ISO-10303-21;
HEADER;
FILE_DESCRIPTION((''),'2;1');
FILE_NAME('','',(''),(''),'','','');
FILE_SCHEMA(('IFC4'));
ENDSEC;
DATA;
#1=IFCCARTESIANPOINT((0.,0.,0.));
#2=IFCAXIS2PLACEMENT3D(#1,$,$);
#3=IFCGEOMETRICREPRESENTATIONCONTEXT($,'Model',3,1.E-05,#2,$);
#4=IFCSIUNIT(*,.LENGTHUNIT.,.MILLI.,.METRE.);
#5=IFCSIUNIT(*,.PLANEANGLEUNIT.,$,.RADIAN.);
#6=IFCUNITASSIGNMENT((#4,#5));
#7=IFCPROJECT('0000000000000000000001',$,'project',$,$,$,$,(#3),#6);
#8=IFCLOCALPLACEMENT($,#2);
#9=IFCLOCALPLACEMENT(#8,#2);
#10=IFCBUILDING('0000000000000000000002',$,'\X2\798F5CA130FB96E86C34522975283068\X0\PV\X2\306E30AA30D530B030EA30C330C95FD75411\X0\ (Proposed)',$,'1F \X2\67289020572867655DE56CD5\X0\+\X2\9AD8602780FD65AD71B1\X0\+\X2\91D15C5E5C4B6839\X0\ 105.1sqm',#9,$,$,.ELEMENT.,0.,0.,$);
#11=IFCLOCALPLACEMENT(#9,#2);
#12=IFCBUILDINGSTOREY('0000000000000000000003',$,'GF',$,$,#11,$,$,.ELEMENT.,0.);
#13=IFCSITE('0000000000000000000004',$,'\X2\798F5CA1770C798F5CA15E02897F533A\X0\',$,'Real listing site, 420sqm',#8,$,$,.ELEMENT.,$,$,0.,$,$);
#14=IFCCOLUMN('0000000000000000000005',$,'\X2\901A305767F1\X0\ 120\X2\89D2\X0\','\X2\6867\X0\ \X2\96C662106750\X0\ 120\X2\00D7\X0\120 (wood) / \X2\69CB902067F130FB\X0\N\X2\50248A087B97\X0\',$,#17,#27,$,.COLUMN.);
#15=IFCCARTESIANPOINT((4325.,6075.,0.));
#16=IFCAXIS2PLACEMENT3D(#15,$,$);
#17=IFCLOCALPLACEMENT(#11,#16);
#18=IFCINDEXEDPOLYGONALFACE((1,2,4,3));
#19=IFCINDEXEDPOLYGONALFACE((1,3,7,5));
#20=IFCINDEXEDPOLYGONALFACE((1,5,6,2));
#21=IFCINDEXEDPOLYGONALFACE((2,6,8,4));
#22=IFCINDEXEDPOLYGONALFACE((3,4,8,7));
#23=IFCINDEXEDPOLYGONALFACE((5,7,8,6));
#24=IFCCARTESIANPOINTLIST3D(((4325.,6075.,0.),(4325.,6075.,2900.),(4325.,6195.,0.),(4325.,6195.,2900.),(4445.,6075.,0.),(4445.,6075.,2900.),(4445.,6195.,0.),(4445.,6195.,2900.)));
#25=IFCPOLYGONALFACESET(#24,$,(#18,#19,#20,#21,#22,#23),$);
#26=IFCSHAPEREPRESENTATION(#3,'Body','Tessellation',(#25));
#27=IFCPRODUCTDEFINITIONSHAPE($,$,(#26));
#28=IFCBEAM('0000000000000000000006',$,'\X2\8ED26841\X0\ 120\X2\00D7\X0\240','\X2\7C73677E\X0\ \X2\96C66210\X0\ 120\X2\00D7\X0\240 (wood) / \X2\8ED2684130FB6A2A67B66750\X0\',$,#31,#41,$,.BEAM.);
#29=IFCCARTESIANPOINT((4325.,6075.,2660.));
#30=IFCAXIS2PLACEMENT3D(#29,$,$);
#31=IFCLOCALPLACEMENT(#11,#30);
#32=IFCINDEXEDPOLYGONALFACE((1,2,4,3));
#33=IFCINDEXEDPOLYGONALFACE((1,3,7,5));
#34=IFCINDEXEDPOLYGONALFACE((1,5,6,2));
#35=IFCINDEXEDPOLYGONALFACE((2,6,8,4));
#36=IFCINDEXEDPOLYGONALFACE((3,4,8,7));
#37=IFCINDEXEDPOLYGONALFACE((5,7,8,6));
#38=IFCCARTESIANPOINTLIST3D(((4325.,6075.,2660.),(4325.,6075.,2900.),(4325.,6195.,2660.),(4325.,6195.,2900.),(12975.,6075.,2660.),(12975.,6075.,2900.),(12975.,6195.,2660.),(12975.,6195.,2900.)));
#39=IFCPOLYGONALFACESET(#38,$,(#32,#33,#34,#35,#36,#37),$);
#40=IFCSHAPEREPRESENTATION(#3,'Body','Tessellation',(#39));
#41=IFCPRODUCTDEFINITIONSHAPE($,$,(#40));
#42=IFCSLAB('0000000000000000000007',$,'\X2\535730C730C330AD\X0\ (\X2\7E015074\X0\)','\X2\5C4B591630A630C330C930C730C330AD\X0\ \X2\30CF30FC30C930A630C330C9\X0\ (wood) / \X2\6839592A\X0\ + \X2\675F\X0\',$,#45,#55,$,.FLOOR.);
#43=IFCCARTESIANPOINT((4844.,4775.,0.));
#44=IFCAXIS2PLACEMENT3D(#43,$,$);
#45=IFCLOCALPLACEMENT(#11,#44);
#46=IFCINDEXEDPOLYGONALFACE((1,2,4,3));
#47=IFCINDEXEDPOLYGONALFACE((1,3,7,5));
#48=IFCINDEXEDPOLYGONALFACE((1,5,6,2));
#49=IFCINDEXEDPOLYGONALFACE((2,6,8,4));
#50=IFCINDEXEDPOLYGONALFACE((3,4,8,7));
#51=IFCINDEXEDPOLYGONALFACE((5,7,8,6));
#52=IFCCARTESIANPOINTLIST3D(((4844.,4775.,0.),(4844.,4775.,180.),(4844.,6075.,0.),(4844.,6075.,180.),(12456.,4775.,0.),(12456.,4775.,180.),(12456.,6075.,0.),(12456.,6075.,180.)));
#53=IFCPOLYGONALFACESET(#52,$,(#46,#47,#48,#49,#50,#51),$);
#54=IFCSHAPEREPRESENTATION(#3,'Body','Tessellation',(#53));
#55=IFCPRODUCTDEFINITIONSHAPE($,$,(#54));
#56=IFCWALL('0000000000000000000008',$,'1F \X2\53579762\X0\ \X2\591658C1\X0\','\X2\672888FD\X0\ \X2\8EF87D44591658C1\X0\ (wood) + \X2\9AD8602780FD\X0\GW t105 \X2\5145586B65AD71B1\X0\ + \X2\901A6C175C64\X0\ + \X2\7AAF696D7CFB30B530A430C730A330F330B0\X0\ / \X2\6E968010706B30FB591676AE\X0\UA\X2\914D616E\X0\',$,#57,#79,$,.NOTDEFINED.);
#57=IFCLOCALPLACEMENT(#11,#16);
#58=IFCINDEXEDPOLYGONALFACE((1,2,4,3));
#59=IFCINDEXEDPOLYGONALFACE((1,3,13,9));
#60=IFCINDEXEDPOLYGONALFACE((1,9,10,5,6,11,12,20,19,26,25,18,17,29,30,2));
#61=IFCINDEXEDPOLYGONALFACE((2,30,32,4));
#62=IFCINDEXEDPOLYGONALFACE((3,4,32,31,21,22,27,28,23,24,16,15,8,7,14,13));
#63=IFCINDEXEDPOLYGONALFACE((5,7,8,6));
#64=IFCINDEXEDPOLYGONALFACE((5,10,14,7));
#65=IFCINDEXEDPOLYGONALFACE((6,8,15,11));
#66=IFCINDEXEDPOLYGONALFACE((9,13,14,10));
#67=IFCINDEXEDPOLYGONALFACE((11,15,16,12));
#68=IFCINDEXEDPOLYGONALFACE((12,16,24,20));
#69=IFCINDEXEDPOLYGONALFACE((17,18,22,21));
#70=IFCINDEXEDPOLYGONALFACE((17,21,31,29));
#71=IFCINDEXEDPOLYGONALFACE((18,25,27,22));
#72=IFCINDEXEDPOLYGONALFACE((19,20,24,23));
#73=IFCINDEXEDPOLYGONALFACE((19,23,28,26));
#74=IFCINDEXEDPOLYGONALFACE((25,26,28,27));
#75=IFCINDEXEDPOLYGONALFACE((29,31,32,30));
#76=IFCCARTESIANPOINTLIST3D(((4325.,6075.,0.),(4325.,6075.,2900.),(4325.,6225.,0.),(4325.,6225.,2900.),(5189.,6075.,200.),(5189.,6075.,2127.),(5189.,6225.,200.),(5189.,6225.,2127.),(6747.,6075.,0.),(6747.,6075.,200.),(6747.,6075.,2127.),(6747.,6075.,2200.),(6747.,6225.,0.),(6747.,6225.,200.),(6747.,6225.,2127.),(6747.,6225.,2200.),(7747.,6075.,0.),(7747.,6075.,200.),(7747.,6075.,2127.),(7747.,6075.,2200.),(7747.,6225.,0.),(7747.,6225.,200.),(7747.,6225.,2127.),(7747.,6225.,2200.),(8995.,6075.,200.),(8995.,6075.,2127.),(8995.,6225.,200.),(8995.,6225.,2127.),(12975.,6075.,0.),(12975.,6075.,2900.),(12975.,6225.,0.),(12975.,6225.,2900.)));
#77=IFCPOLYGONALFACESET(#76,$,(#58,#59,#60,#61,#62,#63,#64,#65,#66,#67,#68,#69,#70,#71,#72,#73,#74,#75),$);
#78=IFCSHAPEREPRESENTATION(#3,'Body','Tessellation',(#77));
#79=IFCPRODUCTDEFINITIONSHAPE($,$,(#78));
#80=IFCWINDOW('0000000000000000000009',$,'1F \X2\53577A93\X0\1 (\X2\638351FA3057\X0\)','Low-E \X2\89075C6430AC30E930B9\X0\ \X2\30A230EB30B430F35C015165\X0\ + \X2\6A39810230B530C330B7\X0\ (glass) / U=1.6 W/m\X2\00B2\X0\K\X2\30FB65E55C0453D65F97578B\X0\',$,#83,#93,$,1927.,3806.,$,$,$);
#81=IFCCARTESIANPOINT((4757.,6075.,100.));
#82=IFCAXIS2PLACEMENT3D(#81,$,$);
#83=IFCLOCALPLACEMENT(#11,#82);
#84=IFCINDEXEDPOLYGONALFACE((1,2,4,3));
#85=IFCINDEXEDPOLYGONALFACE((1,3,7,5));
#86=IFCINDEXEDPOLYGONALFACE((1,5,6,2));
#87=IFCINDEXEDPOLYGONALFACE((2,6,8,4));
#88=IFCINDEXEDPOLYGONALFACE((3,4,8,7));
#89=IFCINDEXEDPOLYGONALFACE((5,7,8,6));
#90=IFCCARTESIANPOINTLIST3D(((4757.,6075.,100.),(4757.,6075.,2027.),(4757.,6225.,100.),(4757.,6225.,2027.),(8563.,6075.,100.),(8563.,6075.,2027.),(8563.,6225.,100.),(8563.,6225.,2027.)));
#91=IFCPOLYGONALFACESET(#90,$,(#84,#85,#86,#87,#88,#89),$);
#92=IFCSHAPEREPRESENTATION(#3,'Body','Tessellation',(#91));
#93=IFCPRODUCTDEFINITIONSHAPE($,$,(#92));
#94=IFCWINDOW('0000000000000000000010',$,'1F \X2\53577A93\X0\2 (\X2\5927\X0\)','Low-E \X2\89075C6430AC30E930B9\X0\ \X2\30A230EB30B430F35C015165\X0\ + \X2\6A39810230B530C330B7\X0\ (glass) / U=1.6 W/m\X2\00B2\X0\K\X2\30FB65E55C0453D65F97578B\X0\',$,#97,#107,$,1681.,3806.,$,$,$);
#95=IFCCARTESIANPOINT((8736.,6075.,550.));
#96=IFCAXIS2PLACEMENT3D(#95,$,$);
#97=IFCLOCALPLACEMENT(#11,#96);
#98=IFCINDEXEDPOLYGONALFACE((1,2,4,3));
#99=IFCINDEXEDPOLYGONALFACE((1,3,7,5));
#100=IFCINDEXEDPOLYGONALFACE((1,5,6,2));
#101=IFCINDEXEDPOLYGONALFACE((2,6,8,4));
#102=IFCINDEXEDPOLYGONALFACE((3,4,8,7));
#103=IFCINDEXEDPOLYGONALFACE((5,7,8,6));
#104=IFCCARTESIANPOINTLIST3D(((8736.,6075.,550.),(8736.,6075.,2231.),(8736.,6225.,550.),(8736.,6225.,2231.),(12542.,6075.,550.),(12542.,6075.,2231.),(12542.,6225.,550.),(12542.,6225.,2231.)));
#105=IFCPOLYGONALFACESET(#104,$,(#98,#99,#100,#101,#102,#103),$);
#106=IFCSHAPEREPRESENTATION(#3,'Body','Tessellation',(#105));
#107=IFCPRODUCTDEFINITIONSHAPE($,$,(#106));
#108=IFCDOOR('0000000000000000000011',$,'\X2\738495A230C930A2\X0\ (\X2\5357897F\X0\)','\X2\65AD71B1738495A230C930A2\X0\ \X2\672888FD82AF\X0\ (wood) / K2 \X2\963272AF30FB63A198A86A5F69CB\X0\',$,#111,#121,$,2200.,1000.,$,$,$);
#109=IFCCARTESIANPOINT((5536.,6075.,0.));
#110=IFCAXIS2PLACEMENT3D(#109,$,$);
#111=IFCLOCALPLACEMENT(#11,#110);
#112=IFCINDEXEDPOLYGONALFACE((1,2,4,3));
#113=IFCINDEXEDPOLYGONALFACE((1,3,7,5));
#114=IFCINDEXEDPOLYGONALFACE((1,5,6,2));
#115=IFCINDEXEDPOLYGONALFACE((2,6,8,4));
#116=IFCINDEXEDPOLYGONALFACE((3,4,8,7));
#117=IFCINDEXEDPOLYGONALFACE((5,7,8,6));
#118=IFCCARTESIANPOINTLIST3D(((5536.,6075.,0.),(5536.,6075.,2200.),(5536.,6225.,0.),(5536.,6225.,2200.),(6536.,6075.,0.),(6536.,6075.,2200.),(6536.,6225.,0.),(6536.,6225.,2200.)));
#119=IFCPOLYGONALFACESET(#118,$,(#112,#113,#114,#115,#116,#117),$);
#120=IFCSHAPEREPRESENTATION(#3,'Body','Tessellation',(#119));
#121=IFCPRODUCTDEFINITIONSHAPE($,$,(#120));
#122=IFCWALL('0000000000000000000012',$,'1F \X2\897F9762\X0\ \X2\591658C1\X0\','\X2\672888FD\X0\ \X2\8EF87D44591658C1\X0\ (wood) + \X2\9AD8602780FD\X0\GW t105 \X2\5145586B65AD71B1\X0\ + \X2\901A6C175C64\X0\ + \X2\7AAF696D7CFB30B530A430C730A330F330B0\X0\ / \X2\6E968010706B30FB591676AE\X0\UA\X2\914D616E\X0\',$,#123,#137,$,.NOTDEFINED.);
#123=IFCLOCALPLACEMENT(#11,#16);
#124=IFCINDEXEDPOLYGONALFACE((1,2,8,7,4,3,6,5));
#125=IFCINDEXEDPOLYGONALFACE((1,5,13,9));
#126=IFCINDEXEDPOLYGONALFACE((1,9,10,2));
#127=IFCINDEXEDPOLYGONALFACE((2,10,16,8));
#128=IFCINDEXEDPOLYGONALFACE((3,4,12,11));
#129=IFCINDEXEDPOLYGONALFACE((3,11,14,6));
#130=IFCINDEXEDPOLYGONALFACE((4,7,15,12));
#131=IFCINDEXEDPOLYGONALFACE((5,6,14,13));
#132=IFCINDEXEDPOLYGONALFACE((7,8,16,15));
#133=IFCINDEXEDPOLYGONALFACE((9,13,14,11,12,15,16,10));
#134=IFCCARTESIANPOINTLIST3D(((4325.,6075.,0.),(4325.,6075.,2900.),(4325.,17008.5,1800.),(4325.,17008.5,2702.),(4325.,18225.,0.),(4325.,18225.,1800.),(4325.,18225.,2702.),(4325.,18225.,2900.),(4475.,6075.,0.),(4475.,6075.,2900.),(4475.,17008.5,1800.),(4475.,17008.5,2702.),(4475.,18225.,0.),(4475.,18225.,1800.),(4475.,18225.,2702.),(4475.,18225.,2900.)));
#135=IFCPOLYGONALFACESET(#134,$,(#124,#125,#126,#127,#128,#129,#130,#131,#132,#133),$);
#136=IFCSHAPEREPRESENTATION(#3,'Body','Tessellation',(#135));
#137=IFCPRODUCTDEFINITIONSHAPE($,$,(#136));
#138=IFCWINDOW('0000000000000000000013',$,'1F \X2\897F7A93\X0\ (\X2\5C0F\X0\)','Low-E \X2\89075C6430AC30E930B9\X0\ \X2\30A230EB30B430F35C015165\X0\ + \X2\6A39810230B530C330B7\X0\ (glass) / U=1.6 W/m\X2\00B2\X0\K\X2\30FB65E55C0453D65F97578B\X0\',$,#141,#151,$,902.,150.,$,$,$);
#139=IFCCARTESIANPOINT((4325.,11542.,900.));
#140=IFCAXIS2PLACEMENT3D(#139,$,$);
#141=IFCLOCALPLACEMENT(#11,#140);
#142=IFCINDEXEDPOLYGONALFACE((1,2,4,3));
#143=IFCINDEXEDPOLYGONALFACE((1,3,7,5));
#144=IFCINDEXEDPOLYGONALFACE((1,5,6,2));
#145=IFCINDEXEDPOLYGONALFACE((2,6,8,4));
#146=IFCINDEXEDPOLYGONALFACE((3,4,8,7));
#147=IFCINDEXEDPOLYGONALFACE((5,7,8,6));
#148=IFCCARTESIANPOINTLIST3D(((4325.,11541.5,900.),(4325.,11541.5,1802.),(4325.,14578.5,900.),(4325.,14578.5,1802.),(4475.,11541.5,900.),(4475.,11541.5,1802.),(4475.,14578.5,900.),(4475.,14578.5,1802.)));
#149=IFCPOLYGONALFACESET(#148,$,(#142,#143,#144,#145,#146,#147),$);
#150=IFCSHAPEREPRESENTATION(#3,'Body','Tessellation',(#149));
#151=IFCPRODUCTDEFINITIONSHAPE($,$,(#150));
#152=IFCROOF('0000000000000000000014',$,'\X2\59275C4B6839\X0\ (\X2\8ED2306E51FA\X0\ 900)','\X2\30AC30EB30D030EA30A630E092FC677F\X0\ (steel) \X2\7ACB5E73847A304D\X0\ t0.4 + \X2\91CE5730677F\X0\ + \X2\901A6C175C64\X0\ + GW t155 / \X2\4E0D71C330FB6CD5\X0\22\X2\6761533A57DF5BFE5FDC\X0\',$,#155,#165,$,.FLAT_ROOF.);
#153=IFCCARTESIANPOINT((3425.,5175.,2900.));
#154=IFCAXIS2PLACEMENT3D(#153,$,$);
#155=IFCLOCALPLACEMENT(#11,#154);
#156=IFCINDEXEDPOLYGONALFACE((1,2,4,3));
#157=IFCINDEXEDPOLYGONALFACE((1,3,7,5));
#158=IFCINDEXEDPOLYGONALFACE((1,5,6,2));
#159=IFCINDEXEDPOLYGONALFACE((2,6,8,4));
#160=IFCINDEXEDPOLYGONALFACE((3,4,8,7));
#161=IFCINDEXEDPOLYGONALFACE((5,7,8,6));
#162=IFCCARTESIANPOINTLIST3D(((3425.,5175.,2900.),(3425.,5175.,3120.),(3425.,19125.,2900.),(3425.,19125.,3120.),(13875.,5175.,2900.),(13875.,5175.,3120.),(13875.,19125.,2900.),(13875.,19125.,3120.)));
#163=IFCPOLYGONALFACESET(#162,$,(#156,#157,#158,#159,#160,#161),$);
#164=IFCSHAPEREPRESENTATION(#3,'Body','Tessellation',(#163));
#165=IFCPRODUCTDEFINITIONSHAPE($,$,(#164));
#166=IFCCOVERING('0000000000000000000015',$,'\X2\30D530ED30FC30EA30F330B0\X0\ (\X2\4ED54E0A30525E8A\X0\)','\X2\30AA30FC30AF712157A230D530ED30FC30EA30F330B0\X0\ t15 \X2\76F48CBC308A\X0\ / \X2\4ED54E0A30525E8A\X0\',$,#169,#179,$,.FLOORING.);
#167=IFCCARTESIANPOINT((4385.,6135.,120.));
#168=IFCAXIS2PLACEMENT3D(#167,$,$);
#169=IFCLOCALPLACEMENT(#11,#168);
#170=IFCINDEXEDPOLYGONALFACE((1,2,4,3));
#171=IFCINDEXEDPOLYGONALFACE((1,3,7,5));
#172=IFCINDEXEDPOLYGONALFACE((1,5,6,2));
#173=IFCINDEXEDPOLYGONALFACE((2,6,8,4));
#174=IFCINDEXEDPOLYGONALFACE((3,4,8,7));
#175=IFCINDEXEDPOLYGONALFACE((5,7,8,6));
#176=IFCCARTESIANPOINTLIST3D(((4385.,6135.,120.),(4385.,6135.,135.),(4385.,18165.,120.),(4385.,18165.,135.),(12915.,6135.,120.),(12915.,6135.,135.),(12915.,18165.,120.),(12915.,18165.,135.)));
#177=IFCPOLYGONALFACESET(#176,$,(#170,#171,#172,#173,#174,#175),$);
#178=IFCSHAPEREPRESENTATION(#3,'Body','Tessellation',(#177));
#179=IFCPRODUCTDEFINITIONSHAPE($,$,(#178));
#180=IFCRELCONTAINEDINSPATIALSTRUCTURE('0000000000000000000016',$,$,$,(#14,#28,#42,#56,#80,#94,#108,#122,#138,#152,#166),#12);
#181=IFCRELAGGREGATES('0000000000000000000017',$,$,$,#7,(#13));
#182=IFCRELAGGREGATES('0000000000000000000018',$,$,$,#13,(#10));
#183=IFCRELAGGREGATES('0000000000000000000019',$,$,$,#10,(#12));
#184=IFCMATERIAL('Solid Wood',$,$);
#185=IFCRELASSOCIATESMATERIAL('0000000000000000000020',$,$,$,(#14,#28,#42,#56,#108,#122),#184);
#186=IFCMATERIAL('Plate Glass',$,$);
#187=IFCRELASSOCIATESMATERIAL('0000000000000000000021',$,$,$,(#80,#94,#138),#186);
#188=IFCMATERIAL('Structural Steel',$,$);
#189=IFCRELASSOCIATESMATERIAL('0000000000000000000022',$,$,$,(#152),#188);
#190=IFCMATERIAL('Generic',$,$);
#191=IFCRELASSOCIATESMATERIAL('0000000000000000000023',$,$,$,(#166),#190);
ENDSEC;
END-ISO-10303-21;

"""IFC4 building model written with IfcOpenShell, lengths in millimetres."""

from ifc_helpers import new_model, si_unit, frame, frame_2d, origin, place, context, project, spatial, rectangle, extrude, material, element, fill, save


model = new_model("IFC4")

# Units and contexts
model_context = context("Model", 3, precision=1e-05, world=origin())
ifc_project = project(units=[si_unit("LENGTHUNIT", "METRE", prefix="MILLI"), si_unit("PLANEANGLEUNIT", "RADIAN")], contexts=[model_context])

# Site, building, storey
site_placement = place(None, origin())
site = spatial("IfcSite", under=ifc_project, at=site_placement, Name="福岡県福岡市西区", ObjectType="Real listing site, 420sqm", CompositionType="ELEMENT", RefElevation=0.0)
building_placement = place(site_placement, origin())
building = spatial("IfcBuilding", under=site, at=building_placement, Name="福岡・雨水利用とPVのオフグリッド志向 (Proposed)", ObjectType="1F 木造在来工法+高性能断熱+金属屋根 105.1sqm", CompositionType="ELEMENT", ElevationOfRefHeight=0.0, ElevationOfTerrain=0.0)
storey_placement = place(building_placement, origin())
storey = spatial("IfcBuildingStorey", under=building, at=storey_placement, Name="GF", CompositionType="ELEMENT", Elevation=0.0)

# Column
ifc_material_1 = material(Name="Solid Wood")
column_1_placement = place(storey_placement, frame((4325.0, 6075.0, 0.0)))
element("IfcColumn", 1, at=column_1_placement, inside=storey, material=ifc_material_1, Name="通し柱 120角", Description="桧 集成材 120×120 (wood) / 構造柱・N値計算", PredefinedType="COLUMN", context=model_context, shape_type="SweptSolid", body=[
    extrude(rectangle(XDim=120.0, YDim=120.0, at=frame_2d((60.0, 60.0))), frame((4325.0, 6075.0, 0.0)), (0.0, 0.0, 1.0), 2900.0),
])

# Beam
beam_1_placement = place(storey_placement, frame((4325.0, 6075.0, 2660.0)))
element("IfcBeam", 2, at=beam_1_placement, inside=storey, material=ifc_material_1, Name="軒桁 120×240", Description="米松 集成 120×240 (wood) / 軒桁・横架材", PredefinedType="BEAM", context=model_context, shape_type="SweptSolid", body=[
    extrude(rectangle(XDim=8650.0, YDim=120.0, at=frame_2d((4325.0, 60.0))), frame((4325.0, 6075.0, 2660.0)), (0.0, 0.0, 1.0), 240.0),
])

# Slab
slab_1_placement = place(storey_placement, frame((4844.0, 4775.0, 0.0)))
element("IfcSlab", 3, at=slab_1_placement, inside=storey, material=ifc_material_1, Name="南デッキ (縁側)", Description="屋外ウッドデッキ ハードウッド (wood) / 根太 + 束", PredefinedType="FLOOR", context=model_context, shape_type="SweptSolid", body=[
    extrude(rectangle(XDim=7612.0, YDim=1300.0, at=frame_2d((3806.0, 650.0))), frame((4844.0, 4775.0, 0.0)), (0.0, 0.0, 1.0), 180.0),
])

# Wall, openings, windows, door
wall_1_placement = place(storey_placement, frame((4325.0, 6075.0, 0.0)))
wall_1 = element("IfcWall", 4, at=wall_1_placement, inside=storey, material=ifc_material_1, Name="1F 南面 外壁", Description="木製 軸組外壁 (wood) + 高性能GW t105 充填断熱 + 通気層 + 窯業系サイディング / 準耐火・外皮UA配慮", PredefinedType="NOTDEFINED", context=model_context, shape_type="SweptSolid", body=[
    extrude(rectangle(XDim=8650.0, YDim=150.0, at=frame_2d((4325.0, 75.0))), frame((4325.0, 6075.0, 0.0)), (0.0, 0.0, 1.0), 2900.0),
])
opening_1_placement = place(storey_placement, frame((4757.0, 6075.0, 100.0)))
opening_1 = element("IfcOpeningElement", 5, at=opening_1_placement, cuts=wall_1, PredefinedType="NOTDEFINED", context=model_context, shape_type="SweptSolid", body=[
    extrude(rectangle(XDim=3806.0, YDim=150.0, at=frame_2d((1903.0, 75.0))), frame((4757.0, 6075.0, 100.0)), (0.0, 0.0, 1.0), 1927.0),
])
opening_2_placement = place(storey_placement, frame((8736.0, 6075.0, 550.0)))
opening_2 = element("IfcOpeningElement", 6, at=opening_2_placement, cuts=wall_1, PredefinedType="NOTDEFINED", context=model_context, shape_type="SweptSolid", body=[
    extrude(rectangle(XDim=3806.0, YDim=150.0, at=frame_2d((1903.0, 75.0))), frame((8736.0, 6075.0, 550.0)), (0.0, 0.0, 1.0), 1681.0),
])
opening_3_placement = place(storey_placement, frame((5536.0, 6075.0, 0.0)))
opening_3 = element("IfcOpeningElement", 7, at=opening_3_placement, cuts=wall_1, PredefinedType="NOTDEFINED", context=model_context, shape_type="SweptSolid", body=[
    extrude(rectangle(XDim=1000.0, YDim=150.0, at=frame_2d((500.0, 75.0))), frame((5536.0, 6075.0, 0.0)), (0.0, 0.0, 1.0), 2200.0),
])
ifc_material_2 = material(Name="Plate Glass")
window_1_placement = place(storey_placement, frame((4757.0, 6075.0, 100.0)))
window_1 = element("IfcWindow", 8, at=window_1_placement, inside=storey, material=ifc_material_2, Name="1F 南窓1 (掃出し)", Description="Low-E 複層ガラス アルゴン封入 + 樹脂サッシ (glass) / U=1.6 W/m²K・日射取得型", OverallHeight=1927.0, OverallWidth=3806.0, context=model_context, shape_type="SweptSolid", body=[
    extrude(rectangle(XDim=3806.0, YDim=150.0, at=frame_2d((1903.0, 75.0))), frame((4757.0, 6075.0, 100.0)), (0.0, 0.0, 1.0), 1927.0),
])
fill(opening_1, window_1)
window_2_placement = place(storey_placement, frame((8736.0, 6075.0, 550.0)))
window_2 = element("IfcWindow", 9, at=window_2_placement, inside=storey, material=ifc_material_2, Name="1F 南窓2 (大)", Description="Low-E 複層ガラス アルゴン封入 + 樹脂サッシ (glass) / U=1.6 W/m²K・日射取得型", OverallHeight=1681.0, OverallWidth=3806.0, context=model_context, shape_type="SweptSolid", body=[
    extrude(rectangle(XDim=3806.0, YDim=150.0, at=frame_2d((1903.0, 75.0))), frame((8736.0, 6075.0, 550.0)), (0.0, 0.0, 1.0), 1681.0),
])
fill(opening_2, window_2)
door_placement = place(storey_placement, frame((5536.0, 6075.0, 0.0)))
door = element("IfcDoor", 10, at=door_placement, inside=storey, material=ifc_material_1, Name="玄関ドア (南西)", Description="断熱玄関ドア 木製芯 (wood) / K2 防犯・採風機構", OverallHeight=2200.0, OverallWidth=1000.0, context=model_context, shape_type="SweptSolid", body=[
    extrude(rectangle(XDim=1000.0, YDim=150.0, at=frame_2d((500.0, 75.0))), frame((5536.0, 6075.0, 0.0)), (0.0, 0.0, 1.0), 2200.0),
])
fill(opening_3, door)

# Wall, opening, window
wall_2_placement = place(storey_placement, frame((4325.0, 6075.0, 0.0)))
wall_2 = element("IfcWall", 11, at=wall_2_placement, inside=storey, material=ifc_material_1, Name="1F 西面 外壁", Description="木製 軸組外壁 (wood) + 高性能GW t105 充填断熱 + 通気層 + 窯業系サイディング / 準耐火・外皮UA配慮", PredefinedType="NOTDEFINED", context=model_context, shape_type="SweptSolid", body=[
    extrude(rectangle(XDim=150.0, YDim=12150.0, at=frame_2d((75.0, 6075.0))), frame((4325.0, 6075.0, 0.0)), (0.0, 0.0, 1.0), 2900.0),
])
opening_4_placement = place(storey_placement, frame((4325.0, 11542.0, 900.0)))
opening_4 = element("IfcOpeningElement", 12, at=opening_4_placement, cuts=wall_2, PredefinedType="NOTDEFINED", context=model_context, shape_type="SweptSolid", body=[
    extrude(rectangle(XDim=150.0, YDim=3037.0, at=frame_2d((75.0, 1518.0))), frame((4325.0, 11542.0, 900.0)), (0.0, 0.0, 1.0), 902.0),
])
window_3_placement = place(storey_placement, frame((4325.0, 11542.0, 900.0)))
window_3 = element("IfcWindow", 13, at=window_3_placement, inside=storey, material=ifc_material_2, Name="1F 西窓 (小)", Description="Low-E 複層ガラス アルゴン封入 + 樹脂サッシ (glass) / U=1.6 W/m²K・日射取得型", OverallHeight=902.0, OverallWidth=150.0, context=model_context, shape_type="SweptSolid", body=[
    extrude(rectangle(XDim=150.0, YDim=3037.0, at=frame_2d((75.0, 1518.0))), frame((4325.0, 11542.0, 900.0)), (0.0, 0.0, 1.0), 902.0),
])
fill(opening_4, window_3)

# Roof
ifc_material_3 = material(Name="Structural Steel")
roof_placement = place(storey_placement, frame((3425.0, 5175.0, 2900.0)))
element("IfcRoof", 14, at=roof_placement, inside=storey, material=ifc_material_3, Name="大屋根 (軒の出 900)", Description="ガルバリウム鋼板 (steel) 立平葺き t0.4 + 野地板 + 通気層 + GW t155 / 不燃・法22条区域対応", PredefinedType="FLAT_ROOF", context=model_context, shape_type="SweptSolid", body=[
    extrude(rectangle(XDim=10450.0, YDim=13950.0, at=frame_2d((5225.0, 6975.0))), frame((3425.0, 5175.0, 2900.0)), (0.0, 0.0, 1.0), 220.0),
])

# Covering
ifc_material_4 = material(Name="Generic")
covering_1_placement = place(storey_placement, frame((4385.0, 6135.0, 120.0)))
element("IfcCovering", 15, at=covering_1_placement, inside=storey, material=ifc_material_4, Name="フローリング (仕上げ床)", Description="オーク無垢フローリング t15 直貼り / 仕上げ床", PredefinedType="FLOORING", context=model_context, shape_type="SweptSolid", body=[
    extrude(rectangle(XDim=8530.0, YDim=12030.0, at=frame_2d((4265.0, 6015.0))), frame((4385.0, 6135.0, 120.0)), (0.0, 0.0, 1.0), 15.0),
])

save(model, "model.ifc")
